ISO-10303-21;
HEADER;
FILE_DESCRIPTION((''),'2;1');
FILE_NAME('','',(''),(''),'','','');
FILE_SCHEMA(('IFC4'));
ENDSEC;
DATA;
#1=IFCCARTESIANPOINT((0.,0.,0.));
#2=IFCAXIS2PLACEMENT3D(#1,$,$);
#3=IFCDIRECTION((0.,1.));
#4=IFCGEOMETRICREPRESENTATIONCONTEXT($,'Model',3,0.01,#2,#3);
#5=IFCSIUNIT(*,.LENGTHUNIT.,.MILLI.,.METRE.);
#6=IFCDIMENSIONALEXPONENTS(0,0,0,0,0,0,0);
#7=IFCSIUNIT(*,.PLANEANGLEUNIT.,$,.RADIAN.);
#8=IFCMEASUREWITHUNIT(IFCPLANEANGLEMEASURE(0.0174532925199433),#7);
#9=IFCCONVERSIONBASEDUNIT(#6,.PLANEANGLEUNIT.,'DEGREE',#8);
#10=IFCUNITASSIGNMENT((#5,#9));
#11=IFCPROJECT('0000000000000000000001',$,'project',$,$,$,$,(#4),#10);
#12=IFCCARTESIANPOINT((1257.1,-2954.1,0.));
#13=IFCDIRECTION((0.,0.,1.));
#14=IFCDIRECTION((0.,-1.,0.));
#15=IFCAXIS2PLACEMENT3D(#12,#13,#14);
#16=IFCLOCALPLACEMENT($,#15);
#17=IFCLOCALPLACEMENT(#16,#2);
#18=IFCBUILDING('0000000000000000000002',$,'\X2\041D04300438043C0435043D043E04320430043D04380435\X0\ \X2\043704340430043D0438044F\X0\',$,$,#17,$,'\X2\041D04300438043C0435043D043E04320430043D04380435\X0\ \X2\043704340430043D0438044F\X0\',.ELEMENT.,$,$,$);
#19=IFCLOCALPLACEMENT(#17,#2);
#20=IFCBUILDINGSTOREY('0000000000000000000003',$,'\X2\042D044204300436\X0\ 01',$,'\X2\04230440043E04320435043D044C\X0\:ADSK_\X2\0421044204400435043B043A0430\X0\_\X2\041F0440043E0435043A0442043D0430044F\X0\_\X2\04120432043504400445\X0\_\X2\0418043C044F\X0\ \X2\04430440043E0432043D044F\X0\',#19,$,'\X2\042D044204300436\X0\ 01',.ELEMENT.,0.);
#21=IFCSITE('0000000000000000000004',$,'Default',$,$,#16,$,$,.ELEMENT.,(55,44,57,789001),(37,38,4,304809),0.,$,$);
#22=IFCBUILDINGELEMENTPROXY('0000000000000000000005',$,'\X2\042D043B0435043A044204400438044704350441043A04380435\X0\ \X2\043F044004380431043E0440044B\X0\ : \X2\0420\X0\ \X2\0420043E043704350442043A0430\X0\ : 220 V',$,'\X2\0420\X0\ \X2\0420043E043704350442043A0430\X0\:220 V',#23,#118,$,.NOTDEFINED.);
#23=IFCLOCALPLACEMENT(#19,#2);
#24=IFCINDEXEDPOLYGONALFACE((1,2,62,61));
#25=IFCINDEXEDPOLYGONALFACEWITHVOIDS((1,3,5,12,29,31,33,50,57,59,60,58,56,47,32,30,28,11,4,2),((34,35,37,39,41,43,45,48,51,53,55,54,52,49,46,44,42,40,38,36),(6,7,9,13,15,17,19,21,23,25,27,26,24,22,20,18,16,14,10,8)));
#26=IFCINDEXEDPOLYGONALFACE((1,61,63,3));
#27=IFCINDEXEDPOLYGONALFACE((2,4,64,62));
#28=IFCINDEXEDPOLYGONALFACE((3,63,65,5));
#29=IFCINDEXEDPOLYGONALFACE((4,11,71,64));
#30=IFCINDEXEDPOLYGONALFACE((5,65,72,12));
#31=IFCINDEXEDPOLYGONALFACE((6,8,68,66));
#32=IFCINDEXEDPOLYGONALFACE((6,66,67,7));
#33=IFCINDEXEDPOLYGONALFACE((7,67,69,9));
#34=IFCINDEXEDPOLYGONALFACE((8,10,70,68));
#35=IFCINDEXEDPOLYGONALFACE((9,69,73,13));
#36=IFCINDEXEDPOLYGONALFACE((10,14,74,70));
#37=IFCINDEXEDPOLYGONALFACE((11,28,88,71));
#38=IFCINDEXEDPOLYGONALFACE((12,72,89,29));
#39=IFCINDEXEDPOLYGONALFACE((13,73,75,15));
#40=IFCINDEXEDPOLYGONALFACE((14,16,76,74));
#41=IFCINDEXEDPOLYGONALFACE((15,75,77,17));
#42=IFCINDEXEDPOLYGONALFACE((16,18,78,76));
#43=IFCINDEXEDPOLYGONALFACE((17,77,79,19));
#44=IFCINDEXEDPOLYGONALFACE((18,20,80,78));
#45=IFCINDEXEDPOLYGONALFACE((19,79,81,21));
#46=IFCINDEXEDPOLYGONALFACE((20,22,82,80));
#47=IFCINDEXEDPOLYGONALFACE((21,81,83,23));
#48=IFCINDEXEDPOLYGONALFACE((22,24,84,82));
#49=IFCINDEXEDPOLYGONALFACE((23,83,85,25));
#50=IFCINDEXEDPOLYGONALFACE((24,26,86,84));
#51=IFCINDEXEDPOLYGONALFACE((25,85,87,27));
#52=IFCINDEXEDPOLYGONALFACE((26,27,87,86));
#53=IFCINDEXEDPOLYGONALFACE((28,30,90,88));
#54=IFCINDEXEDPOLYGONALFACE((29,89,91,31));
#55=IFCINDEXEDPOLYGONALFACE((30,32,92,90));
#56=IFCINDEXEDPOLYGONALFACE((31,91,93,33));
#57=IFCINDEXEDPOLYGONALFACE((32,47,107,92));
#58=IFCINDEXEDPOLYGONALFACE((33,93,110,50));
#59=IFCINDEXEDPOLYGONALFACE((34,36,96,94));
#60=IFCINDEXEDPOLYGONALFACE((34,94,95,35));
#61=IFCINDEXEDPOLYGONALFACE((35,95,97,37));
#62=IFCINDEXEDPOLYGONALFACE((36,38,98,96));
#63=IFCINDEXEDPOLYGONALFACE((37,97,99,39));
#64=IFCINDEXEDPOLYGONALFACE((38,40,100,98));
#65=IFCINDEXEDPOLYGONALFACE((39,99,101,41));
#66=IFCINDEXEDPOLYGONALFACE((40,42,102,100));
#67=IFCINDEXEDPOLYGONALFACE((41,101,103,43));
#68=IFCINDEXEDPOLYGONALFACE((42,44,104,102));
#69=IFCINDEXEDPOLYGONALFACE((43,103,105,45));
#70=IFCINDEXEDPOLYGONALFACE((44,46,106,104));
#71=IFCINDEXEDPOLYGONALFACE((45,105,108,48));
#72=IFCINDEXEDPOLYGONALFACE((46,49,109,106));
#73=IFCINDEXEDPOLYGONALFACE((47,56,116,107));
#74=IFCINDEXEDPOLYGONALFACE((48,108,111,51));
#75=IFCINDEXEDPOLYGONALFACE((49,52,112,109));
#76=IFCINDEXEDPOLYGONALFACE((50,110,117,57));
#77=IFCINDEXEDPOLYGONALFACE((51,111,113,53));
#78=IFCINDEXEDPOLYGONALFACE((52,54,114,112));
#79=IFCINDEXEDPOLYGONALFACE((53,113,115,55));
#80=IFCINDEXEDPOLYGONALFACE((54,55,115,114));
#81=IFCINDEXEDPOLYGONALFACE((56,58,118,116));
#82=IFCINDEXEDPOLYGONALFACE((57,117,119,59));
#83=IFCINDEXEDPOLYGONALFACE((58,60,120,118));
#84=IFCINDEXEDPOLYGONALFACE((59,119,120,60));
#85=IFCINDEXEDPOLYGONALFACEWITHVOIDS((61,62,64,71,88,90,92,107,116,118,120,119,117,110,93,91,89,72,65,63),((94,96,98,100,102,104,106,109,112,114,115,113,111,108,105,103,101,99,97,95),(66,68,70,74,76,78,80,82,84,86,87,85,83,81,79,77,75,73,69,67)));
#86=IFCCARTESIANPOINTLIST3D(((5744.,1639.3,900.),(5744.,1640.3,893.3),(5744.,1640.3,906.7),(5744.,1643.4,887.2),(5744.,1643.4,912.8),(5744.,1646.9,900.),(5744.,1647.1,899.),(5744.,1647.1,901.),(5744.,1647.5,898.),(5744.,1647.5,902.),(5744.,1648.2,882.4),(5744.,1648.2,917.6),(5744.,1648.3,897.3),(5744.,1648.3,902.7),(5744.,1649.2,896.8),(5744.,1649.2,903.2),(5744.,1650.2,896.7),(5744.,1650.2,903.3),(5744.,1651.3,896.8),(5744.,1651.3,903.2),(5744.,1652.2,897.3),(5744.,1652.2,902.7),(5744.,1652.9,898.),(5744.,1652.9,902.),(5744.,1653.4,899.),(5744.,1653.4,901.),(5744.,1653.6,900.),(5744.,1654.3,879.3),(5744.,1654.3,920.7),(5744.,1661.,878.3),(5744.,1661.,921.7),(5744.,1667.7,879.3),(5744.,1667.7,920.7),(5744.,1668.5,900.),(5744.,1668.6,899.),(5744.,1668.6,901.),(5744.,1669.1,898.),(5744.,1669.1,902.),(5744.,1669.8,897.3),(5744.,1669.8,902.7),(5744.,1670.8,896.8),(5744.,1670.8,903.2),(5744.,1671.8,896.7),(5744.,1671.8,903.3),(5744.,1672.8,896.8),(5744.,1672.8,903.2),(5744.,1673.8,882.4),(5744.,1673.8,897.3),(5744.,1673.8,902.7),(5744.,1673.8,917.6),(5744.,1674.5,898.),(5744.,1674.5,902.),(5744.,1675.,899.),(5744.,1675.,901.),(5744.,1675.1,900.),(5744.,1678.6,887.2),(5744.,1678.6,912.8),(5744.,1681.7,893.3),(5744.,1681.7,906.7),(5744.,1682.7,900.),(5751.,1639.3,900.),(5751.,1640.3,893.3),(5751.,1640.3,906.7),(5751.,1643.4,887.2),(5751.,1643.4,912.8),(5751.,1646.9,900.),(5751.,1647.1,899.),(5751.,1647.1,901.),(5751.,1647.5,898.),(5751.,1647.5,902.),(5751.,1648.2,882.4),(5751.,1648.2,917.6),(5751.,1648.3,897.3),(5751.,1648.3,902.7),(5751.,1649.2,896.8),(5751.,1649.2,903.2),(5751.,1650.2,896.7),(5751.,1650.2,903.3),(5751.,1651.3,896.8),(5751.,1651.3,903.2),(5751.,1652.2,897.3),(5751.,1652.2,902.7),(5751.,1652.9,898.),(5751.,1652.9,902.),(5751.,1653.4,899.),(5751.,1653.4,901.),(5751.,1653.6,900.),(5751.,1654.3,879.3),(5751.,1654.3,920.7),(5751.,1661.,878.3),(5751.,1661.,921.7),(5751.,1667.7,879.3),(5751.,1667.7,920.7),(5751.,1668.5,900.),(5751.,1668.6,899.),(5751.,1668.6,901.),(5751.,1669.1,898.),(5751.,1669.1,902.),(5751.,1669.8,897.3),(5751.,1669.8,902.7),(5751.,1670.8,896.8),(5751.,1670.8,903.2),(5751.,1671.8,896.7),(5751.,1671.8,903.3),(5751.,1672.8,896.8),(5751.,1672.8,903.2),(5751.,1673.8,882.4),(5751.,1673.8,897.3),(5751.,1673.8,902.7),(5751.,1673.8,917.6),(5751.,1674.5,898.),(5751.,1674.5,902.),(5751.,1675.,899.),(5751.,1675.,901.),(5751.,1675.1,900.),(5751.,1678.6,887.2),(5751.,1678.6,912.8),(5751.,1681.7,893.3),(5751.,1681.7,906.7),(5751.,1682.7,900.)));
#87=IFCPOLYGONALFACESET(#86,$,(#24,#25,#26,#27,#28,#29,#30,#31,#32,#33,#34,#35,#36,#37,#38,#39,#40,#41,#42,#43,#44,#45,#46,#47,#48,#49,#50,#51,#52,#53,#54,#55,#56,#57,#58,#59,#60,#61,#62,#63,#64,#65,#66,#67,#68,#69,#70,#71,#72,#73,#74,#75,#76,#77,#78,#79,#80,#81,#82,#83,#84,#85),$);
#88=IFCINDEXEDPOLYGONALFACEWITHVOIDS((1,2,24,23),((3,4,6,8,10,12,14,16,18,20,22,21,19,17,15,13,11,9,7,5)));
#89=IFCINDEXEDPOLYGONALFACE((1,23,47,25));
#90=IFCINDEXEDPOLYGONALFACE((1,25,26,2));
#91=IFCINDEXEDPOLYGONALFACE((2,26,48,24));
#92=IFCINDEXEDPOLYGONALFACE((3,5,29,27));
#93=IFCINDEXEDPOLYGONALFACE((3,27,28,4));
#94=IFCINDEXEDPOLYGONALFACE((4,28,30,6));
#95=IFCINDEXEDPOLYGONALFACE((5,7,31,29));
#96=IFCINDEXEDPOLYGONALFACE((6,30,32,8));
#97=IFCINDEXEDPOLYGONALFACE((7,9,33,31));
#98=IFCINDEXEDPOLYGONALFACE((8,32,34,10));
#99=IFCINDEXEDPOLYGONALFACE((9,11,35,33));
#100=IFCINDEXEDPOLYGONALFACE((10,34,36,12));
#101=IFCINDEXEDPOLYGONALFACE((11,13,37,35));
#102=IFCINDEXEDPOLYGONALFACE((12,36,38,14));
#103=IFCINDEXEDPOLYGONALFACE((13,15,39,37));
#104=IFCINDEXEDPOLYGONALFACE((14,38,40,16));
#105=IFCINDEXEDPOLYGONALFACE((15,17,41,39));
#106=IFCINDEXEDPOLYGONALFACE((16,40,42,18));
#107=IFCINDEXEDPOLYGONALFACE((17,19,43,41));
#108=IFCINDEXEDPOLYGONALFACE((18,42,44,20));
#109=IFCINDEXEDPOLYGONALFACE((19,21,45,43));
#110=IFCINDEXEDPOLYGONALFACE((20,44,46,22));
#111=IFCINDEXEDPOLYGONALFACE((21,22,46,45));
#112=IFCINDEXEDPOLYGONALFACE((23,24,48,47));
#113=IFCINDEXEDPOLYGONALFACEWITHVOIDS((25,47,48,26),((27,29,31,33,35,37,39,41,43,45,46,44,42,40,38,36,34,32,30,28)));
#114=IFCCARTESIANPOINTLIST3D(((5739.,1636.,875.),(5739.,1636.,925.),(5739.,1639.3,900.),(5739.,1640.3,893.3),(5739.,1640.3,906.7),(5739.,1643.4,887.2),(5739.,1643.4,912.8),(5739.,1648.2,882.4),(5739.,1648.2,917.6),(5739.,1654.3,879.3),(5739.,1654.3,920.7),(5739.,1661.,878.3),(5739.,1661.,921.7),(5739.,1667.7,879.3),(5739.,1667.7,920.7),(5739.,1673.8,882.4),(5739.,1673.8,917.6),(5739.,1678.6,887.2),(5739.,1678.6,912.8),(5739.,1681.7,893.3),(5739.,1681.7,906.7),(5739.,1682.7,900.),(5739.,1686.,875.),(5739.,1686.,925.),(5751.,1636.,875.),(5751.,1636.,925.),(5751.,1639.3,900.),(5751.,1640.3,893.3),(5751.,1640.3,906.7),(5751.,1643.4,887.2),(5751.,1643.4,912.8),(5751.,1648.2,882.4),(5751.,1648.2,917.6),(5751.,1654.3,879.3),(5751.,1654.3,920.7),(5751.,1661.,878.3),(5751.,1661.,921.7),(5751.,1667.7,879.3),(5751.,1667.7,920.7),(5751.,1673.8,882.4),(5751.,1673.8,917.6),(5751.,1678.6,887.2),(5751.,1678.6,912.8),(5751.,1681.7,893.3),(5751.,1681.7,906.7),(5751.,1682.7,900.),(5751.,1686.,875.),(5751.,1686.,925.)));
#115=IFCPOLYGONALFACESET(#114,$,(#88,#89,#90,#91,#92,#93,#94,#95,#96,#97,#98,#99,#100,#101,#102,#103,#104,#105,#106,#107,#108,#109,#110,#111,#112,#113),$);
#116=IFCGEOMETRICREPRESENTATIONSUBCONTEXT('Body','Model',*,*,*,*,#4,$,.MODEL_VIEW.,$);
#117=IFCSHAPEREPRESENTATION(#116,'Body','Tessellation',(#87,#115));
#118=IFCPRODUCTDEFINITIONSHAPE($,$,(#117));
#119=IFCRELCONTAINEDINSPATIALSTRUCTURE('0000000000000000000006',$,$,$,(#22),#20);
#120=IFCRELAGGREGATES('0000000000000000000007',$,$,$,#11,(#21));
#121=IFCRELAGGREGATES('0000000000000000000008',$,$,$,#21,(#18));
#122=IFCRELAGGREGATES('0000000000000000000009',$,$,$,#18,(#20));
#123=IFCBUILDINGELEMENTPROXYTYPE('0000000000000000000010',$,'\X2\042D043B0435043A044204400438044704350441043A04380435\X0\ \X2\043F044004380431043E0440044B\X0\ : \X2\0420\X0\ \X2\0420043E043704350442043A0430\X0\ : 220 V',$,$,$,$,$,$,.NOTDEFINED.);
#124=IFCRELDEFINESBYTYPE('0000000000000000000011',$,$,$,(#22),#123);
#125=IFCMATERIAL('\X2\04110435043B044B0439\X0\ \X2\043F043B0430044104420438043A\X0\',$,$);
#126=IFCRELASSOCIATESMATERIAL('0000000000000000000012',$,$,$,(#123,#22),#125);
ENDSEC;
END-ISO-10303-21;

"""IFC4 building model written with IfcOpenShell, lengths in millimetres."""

from ifc_helpers import new_model, entity, si_unit, converted_unit, direction, frame, origin, place, context, subcontext, project, spatial, indexed_curve, outline, extrude, source, transform, mapped, material, type_object, type_shapes, element, save


model = new_model("IFC4")

# Units and contexts
model_context = context("Model", 3, precision=0.01, world=origin(), true_north=direction((0.0, 1.0)))
body_context = subcontext(model_context, "Body", "Model", "MODEL_VIEW")
ifc_project = project(units=[si_unit("LENGTHUNIT", "METRE", prefix="MILLI"), converted_unit("PLANEANGLEUNIT", "DEGREE", entity("IfcPlaneAngleMeasure", 0.0174532925199433), si_unit("PLANEANGLEUNIT", "RADIAN"), dimensions=[0, 0, 0, 0, 0, 0, 0])], contexts=[model_context])

# Site, building, storey
site_placement = place(None, frame((1257.1, -2954.1, 0.0), z_axis=(0.0, 0.0, 1.0), x_axis=(0.0, -1.0, 0.0)))
site = spatial("IfcSite", under=ifc_project, at=site_placement, Name="Default", CompositionType="ELEMENT", RefLatitude=(55, 44, 57, 789001), RefLongitude=(37, 38, 4, 304809), RefElevation=0.0)
building_placement = place(site_placement, origin())
building = spatial("IfcBuilding", under=site, at=building_placement, Name="Наименование здания", LongName="Наименование здания", CompositionType="ELEMENT")
storey_placement = place(building_placement, origin())
storey = spatial("IfcBuildingStorey", under=building, at=storey_placement, Name="Этаж 01", ObjectType="Уровень:ADSK_Стрелка_Проектная_Вверх_Имя уровня", LongName="Этаж 01", CompositionType="ELEMENT", Elevation=0.0)

# Building element proxy
ifc_material_1 = material(Name="Белый пластик")
building_element_proxy_type_1 = type_object("IfcBuildingElementProxyType", Name="Электрические приборы : Р Розетка : 220 V", PredefinedType="NOTDEFINED", material=ifc_material_1)
shared_shape_1 = source(origin(), body_context, "Body", "SweptSolid", [
    extrude(outline(indexed_curve([(21.7, 0.0), (20.7, 6.7), (17.6, 12.8), (12.8, 17.6), (6.7, 20.7), (0.0, 21.7), (-6.7, 20.7), (-12.8, 17.6), (-17.6, 12.8), (-20.7, 6.7), (-21.7, 0.0), (-20.7, -6.7), (-17.6, -12.8), (-12.8, -17.6), (-6.7, -20.7), (0.0, -21.7), (6.7, -20.7), (12.8, -17.6), (17.6, -12.8), (20.7, -6.7), (21.7, 0.0)], self_intersect=False), holes=[indexed_curve([(-7.5, 0.0), (-7.6, -1.0), (-8.1, -2.0), (-8.8, -2.7), (-9.8, -3.2), (-10.8, -3.3), (-11.8, -3.2), (-12.8, -2.7), (-13.5, -2.0), (-14.0, -1.0), (-14.1, 0.0), (-14.0, 1.0), (-13.5, 2.0), (-12.8, 2.7), (-11.8, 3.2), (-10.8, 3.3), (-9.8, 3.2), (-8.8, 2.7), (-8.1, 2.0), (-7.6, 1.0), (-7.5, 0.0)], self_intersect=False), indexed_curve([(14.1, 0.0), (13.9, -1.0), (13.5, -2.0), (12.7, -2.7), (11.8, -3.2), (10.8, -3.3), (9.7, -3.2), (8.8, -2.7), (8.1, -2.0), (7.6, -1.0), (7.4, 0.0), (7.6, 1.0), (8.1, 2.0), (8.8, 2.7), (9.7, 3.2), (10.8, 3.3), (11.8, 3.2), (12.7, 2.7), (13.5, 2.0), (13.9, 1.0), (14.1, 0.0)], self_intersect=False)]), frame((359.8, -712.5, 0.0)), (0.0, 0.0, 1.0), 7.0),
    extrude(outline(indexed_curve([(-25.0, -25.0), (25.0, -25.0), (25.0, 25.0), (-25.0, 25.0), (-25.0, -25.0)], self_intersect=False), holes=[indexed_curve([(-21.7, 0.0), (-20.7, 6.7), (-17.6, 12.8), (-12.8, 17.6), (-6.7, 20.7), (0.0, 21.7), (6.7, 20.7), (12.8, 17.6), (17.6, 12.8), (20.7, 6.7), (21.7, 0.0), (20.7, -6.7), (17.6, -12.8), (12.8, -17.6), (6.7, -20.7), (0.0, -21.7), (-6.7, -20.7), (-12.8, -17.6), (-17.6, -12.8), (-20.7, -6.7), (-21.7, 0.0)], self_intersect=False)]), frame((359.8, -712.5, 0.0), z_axis=(0.0, 0.0, 1.0), x_axis=(-1.0, 0.0, 0.0)), (0.0, 0.0, 1.0), 12.0),
])
type_shapes(building_element_proxy_type_1, [shared_shape_1])
proxy_1_placement = place(storey_placement, frame((5751.0, 2020.8, 1612.5), z_axis=(-1.0, 0.0, 0.0), x_axis=(0.0, -1.0, 0.0)))
element("IfcBuildingElementProxy", 1, at=proxy_1_placement, inside=storey, type_object=building_element_proxy_type_1, material=ifc_material_1, Name="Электрические приборы : Р Розетка : 220 V", ObjectType="Р Розетка:220 V", PredefinedType="NOTDEFINED", context=body_context, shape_type="MappedRepresentation", body=[
    mapped(shared_shape_1, transform((0.0, 0.0, 0.0), scale=1.0)),
])

save(model, "model.ifc")
